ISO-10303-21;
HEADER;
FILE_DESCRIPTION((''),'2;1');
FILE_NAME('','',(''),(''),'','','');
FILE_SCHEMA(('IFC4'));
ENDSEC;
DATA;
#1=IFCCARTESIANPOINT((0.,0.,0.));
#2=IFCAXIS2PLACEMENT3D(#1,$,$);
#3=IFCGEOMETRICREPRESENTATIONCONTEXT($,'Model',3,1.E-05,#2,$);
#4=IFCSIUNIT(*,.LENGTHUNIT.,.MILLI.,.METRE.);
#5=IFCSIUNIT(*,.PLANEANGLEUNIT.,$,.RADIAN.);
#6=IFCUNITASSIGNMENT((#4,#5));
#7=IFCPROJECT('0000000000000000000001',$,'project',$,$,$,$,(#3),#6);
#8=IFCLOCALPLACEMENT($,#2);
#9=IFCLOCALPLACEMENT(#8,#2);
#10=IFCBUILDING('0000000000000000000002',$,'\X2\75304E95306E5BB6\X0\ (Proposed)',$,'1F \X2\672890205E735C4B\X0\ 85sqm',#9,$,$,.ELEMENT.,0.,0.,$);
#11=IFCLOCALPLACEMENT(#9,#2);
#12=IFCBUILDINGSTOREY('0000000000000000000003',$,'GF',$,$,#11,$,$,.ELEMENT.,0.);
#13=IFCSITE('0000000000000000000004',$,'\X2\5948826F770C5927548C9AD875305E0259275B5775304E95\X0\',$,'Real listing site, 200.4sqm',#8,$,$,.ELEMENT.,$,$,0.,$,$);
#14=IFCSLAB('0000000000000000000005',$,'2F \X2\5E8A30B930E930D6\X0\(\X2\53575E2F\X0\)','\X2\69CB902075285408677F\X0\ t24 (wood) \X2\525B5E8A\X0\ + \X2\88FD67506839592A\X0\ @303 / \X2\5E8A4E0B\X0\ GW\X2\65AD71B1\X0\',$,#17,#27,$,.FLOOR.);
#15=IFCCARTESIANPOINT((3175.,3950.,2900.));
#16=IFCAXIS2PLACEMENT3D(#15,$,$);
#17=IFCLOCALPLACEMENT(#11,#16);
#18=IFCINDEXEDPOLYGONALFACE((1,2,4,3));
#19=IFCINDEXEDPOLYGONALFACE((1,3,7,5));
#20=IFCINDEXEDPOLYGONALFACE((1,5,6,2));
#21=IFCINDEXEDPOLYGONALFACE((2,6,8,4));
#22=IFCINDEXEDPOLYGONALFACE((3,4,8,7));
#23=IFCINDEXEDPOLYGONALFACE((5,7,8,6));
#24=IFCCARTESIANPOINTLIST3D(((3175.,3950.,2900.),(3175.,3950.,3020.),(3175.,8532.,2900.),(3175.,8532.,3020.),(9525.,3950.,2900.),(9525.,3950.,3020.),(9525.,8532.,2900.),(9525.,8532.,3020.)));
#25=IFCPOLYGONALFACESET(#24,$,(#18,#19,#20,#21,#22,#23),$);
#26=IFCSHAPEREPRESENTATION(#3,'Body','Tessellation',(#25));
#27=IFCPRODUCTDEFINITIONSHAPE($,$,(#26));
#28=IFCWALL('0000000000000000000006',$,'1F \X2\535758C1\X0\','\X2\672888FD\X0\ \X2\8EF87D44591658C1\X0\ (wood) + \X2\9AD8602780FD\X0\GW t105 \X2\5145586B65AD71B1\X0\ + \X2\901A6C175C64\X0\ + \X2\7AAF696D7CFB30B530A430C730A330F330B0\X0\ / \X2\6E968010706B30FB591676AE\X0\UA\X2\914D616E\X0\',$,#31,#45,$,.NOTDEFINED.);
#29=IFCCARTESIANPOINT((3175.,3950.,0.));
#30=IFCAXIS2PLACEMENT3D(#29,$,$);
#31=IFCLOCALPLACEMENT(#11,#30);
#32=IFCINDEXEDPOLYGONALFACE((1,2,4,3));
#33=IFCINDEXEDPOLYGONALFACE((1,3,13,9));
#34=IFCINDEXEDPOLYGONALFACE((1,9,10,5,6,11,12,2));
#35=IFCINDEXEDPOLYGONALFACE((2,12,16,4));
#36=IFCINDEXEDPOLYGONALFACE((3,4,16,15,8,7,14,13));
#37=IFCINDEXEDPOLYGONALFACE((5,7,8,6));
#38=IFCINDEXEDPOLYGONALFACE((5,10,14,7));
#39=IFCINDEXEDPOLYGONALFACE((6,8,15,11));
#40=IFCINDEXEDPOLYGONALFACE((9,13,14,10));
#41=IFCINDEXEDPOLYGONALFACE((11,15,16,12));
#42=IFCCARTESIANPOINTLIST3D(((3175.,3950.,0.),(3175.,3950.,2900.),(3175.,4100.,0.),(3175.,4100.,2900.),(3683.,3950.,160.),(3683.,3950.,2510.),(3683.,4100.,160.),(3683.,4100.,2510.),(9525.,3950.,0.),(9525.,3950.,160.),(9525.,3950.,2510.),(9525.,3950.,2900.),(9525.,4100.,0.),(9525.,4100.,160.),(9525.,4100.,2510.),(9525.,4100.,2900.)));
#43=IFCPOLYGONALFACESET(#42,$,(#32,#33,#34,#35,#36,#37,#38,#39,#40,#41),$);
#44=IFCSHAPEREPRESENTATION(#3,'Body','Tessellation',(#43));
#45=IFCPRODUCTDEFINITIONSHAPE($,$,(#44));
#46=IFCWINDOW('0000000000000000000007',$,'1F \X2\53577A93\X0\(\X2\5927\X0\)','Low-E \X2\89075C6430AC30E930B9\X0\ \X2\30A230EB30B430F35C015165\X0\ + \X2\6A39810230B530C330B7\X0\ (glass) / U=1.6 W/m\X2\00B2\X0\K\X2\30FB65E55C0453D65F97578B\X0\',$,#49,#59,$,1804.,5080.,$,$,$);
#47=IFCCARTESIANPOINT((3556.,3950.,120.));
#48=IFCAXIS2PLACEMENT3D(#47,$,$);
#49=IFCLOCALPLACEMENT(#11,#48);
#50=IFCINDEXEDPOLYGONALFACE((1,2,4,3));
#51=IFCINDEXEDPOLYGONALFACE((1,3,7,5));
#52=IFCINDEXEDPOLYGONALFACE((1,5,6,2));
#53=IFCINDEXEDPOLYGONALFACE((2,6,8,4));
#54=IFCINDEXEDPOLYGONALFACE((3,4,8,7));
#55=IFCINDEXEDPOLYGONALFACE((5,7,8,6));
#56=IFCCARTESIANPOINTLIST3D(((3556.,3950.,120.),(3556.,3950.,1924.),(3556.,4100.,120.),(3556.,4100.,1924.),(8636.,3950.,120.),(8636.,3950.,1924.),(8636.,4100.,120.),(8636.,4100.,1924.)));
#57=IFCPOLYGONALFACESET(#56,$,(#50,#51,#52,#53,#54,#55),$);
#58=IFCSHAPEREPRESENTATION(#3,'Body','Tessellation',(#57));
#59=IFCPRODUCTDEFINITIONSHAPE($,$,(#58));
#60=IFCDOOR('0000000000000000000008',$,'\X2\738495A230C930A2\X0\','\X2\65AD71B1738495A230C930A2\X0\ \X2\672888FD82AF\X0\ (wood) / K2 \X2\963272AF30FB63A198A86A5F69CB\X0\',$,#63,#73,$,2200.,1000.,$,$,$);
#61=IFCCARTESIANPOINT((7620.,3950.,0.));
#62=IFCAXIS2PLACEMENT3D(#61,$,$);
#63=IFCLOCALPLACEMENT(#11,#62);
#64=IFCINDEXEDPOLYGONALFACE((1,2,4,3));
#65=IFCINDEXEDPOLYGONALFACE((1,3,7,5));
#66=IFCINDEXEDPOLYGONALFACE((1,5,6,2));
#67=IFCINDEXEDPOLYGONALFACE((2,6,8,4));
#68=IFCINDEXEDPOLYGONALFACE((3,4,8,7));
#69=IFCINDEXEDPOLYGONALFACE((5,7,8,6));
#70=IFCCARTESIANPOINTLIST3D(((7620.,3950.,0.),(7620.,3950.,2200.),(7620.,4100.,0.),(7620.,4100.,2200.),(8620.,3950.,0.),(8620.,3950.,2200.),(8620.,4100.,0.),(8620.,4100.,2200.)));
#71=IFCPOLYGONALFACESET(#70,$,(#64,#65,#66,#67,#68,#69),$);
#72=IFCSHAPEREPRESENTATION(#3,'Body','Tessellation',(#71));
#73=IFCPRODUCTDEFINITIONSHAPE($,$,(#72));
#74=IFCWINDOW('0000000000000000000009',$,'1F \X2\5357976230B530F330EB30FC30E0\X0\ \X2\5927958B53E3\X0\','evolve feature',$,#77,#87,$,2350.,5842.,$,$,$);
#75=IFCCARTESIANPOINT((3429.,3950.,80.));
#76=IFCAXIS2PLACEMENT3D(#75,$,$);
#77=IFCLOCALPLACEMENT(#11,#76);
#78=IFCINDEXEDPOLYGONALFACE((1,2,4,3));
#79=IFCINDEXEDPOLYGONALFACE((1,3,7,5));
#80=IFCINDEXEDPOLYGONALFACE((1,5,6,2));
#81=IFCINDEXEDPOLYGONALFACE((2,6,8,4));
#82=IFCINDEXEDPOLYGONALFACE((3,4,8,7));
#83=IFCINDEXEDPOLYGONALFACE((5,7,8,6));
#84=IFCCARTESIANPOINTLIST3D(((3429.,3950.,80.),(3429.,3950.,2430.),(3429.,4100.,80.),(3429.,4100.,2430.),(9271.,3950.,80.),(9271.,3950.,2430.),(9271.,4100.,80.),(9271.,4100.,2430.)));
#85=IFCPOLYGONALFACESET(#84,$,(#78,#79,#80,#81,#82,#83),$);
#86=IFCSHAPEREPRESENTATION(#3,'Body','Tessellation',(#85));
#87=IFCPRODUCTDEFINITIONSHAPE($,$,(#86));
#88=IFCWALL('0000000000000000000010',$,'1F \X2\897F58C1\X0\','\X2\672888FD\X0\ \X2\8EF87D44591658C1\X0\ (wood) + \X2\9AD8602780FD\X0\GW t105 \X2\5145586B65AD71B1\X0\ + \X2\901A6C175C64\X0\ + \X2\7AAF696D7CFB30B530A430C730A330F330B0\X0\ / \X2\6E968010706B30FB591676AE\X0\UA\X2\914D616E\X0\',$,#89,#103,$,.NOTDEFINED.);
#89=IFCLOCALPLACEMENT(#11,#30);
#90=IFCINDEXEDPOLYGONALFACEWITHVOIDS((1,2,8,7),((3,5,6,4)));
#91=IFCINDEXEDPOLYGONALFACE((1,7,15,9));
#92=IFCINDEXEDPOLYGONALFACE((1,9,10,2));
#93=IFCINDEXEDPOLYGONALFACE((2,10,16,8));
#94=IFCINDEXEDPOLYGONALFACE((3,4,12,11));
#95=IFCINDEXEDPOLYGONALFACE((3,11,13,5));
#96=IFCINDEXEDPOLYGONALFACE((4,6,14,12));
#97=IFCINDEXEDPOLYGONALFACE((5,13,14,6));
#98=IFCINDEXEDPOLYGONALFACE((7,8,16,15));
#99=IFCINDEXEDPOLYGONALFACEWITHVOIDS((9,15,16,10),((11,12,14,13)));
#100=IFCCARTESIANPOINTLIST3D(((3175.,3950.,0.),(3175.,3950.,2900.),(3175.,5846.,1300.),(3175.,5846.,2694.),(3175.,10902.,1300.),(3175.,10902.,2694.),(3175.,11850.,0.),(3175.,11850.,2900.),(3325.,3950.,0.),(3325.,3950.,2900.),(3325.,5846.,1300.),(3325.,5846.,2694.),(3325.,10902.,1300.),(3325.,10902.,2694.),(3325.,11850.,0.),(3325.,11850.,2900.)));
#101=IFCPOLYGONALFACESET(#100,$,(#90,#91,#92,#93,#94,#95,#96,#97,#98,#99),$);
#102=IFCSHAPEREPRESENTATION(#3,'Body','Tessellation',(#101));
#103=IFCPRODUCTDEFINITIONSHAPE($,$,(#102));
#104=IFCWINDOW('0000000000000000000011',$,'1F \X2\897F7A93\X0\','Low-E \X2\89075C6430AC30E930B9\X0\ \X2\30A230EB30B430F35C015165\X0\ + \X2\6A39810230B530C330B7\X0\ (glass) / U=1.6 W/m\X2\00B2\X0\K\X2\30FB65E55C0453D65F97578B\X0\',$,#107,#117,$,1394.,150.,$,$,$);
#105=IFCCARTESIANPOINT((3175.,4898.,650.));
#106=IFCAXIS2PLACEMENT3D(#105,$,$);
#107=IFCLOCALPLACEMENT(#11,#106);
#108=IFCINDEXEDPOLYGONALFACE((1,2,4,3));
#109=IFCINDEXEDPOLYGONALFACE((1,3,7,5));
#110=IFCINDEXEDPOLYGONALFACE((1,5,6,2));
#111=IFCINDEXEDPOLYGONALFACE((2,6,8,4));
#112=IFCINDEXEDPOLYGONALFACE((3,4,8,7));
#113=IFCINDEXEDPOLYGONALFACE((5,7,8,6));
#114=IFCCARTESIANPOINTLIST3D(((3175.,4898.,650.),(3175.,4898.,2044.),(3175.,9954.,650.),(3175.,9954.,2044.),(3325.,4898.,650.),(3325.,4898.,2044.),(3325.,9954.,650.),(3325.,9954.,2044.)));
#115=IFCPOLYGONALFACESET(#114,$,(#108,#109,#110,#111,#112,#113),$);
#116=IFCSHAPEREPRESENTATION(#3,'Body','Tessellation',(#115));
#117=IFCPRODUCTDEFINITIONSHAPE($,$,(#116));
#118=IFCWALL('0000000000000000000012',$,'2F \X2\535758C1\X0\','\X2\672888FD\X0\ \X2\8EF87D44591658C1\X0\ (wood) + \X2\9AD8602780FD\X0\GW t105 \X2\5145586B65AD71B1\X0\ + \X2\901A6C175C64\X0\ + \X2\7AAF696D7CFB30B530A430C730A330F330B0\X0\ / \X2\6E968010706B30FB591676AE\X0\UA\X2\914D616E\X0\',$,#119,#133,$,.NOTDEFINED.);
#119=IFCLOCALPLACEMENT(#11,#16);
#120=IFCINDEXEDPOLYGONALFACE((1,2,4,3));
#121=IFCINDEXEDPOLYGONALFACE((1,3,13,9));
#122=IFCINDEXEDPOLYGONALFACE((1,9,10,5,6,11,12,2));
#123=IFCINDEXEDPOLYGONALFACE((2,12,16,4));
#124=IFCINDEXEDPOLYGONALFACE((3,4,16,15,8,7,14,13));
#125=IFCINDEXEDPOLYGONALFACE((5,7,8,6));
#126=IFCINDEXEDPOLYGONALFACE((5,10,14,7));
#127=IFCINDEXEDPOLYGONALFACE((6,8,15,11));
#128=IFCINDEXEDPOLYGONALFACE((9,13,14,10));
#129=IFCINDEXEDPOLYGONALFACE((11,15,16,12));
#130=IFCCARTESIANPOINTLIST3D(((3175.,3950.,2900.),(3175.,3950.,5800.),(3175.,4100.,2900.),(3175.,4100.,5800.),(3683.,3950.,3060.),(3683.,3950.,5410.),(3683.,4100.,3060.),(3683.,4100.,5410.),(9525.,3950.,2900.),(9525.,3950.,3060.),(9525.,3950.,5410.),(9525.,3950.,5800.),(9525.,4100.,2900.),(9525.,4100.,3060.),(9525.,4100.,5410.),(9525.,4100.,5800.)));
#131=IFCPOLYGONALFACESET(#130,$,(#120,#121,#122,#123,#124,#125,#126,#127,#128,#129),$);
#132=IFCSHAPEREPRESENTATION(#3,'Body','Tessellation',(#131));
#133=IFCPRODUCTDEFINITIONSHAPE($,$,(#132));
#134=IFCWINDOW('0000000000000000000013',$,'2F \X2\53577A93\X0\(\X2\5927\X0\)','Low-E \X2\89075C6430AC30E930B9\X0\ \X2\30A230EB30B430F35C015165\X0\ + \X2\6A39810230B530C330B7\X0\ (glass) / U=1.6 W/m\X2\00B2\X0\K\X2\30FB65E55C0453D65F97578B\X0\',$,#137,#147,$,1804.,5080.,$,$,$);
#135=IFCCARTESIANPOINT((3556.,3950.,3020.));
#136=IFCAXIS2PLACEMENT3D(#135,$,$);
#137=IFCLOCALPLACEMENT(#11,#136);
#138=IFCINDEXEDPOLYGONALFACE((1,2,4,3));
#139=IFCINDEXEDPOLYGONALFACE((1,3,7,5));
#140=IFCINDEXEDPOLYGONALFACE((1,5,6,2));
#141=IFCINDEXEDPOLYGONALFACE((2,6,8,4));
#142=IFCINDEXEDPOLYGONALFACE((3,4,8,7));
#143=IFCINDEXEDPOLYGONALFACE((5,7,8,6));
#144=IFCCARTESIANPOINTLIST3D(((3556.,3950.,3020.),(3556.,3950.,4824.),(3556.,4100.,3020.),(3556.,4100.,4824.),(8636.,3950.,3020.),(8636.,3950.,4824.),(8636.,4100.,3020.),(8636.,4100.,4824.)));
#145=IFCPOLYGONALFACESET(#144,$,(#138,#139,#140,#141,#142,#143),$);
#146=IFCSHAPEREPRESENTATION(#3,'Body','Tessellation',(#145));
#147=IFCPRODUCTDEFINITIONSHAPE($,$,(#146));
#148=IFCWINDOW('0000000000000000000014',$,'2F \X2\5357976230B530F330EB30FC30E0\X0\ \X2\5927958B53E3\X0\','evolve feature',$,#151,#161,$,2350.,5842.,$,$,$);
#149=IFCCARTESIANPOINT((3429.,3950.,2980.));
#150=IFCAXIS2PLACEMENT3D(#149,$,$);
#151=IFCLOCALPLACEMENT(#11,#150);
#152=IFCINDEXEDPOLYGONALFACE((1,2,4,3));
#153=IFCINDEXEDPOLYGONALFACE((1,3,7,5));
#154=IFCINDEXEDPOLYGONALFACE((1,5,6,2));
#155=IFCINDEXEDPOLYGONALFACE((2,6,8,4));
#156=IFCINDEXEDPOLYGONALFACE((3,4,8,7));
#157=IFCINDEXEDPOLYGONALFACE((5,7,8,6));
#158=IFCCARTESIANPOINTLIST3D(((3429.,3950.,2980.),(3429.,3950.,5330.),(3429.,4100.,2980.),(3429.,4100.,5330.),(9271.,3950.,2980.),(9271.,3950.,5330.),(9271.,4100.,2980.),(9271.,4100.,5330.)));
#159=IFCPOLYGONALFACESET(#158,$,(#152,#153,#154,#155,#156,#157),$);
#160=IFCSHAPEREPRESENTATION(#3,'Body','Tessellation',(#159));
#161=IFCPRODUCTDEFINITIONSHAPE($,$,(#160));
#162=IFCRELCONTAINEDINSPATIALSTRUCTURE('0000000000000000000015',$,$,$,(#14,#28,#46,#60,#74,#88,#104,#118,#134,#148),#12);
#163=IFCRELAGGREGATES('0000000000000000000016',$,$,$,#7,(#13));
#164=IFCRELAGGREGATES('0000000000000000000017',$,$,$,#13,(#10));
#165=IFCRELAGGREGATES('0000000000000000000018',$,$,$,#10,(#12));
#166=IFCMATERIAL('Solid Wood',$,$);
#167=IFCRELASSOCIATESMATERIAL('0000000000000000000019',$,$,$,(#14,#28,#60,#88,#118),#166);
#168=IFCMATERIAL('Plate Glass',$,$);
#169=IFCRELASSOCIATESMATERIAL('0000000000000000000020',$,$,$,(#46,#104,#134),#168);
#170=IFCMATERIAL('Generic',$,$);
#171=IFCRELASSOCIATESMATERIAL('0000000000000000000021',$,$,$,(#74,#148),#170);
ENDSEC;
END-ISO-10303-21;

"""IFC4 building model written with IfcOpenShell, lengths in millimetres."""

from ifc_helpers import new_model, si_unit, frame, frame_2d, origin, place, context, project, spatial, rectangle, extrude, material, element, fill, save


model = new_model("IFC4")

# Units and contexts
model_context = context("Model", 3, precision=1e-05, world=origin())
ifc_project = project(units=[si_unit("LENGTHUNIT", "METRE", prefix="MILLI"), si_unit("PLANEANGLEUNIT", "RADIAN")], contexts=[model_context])

# Site, building, storey
site_placement = place(None, origin())
site = spatial("IfcSite", under=ifc_project, at=site_placement, Name="奈良県大和高田市大字田井", ObjectType="Real listing site, 200.4sqm", CompositionType="ELEMENT", RefElevation=0.0)
building_placement = place(site_placement, origin())
building = spatial("IfcBuilding", under=site, at=building_placement, Name="田井の家 (Proposed)", ObjectType="1F 木造平屋 85sqm", CompositionType="ELEMENT", ElevationOfRefHeight=0.0, ElevationOfTerrain=0.0)
storey_placement = place(building_placement, origin())
storey = spatial("IfcBuildingStorey", under=building, at=storey_placement, Name="GF", CompositionType="ELEMENT", Elevation=0.0)

# Slab
ifc_material_1 = material(Name="Solid Wood")
slab_1_placement = place(storey_placement, frame((3175.0, 3950.0, 2900.0)))
element("IfcSlab", 1, at=slab_1_placement, inside=storey, material=ifc_material_1, Name="2F 床スラブ(南帯)", Description="構造用合板 t24 (wood) 剛床 + 製材根太 @303 / 床下 GW断熱", PredefinedType="FLOOR", context=model_context, shape_type="SweptSolid", body=[
    extrude(rectangle(XDim=6350.0, YDim=4582.0, at=frame_2d((3175.0, 2291.0))), frame((3175.0, 3950.0, 2900.0)), (0.0, 0.0, 1.0), 120.0),
])
ifc_material_2 = material(Name="Generic")

# Wall, openings, windows, door
wall_1_placement = place(storey_placement, frame((3175.0, 3950.0, 0.0)))
wall_1 = element("IfcWall", 2, at=wall_1_placement, inside=storey, material=ifc_material_1, Name="1F 南壁", Description="木製 軸組外壁 (wood) + 高性能GW t105 充填断熱 + 通気層 + 窯業系サイディング / 準耐火・外皮UA配慮", PredefinedType="NOTDEFINED", context=model_context, shape_type="SweptSolid", body=[
    extrude(rectangle(XDim=6350.0, YDim=150.0, at=frame_2d((3175.0, 75.0))), frame((3175.0, 3950.0, 0.0)), (0.0, 0.0, 1.0), 2900.0),
])
opening_1_placement = place(storey_placement, frame((3556.0, 3950.0, 120.0)))
opening_1 = element("IfcOpeningElement", 3, at=opening_1_placement, cuts=wall_1, PredefinedType="NOTDEFINED", context=model_context, shape_type="SweptSolid", body=[
    extrude(rectangle(XDim=5080.0, YDim=150.0, at=frame_2d((2540.0, 75.0))), frame((3556.0, 3950.0, 120.0)), (0.0, 0.0, 1.0), 1804.0),
])
opening_2_placement = place(storey_placement, frame((7620.0, 3950.0, 0.0)))
opening_2 = element("IfcOpeningElement", 4, at=opening_2_placement, cuts=wall_1, PredefinedType="NOTDEFINED", context=model_context, shape_type="SweptSolid", body=[
    extrude(rectangle(XDim=1000.0, YDim=150.0, at=frame_2d((500.0, 75.0))), frame((7620.0, 3950.0, 0.0)), (0.0, 0.0, 1.0), 2200.0),
])
opening_3_placement = place(storey_placement, frame((3429.0, 3950.0, 80.0)))
opening_3 = element("IfcOpeningElement", 5, at=opening_3_placement, cuts=wall_1, PredefinedType="NOTDEFINED", context=model_context, shape_type="SweptSolid", body=[
    extrude(rectangle(XDim=5842.0, YDim=150.0, at=frame_2d((2921.0, 75.0))), frame((3429.0, 3950.0, 80.0)), (0.0, 0.0, 1.0), 2350.0),
])
ifc_material_3 = material(Name="Plate Glass")
window_1_placement = place(storey_placement, frame((3556.0, 3950.0, 120.0)))
window_1 = element("IfcWindow", 6, at=window_1_placement, inside=storey, material=ifc_material_3, Name="1F 南窓(大)", Description="Low-E 複層ガラス アルゴン封入 + 樹脂サッシ (glass) / U=1.6 W/m²K・日射取得型", OverallHeight=1804.0, OverallWidth=5080.0, context=model_context, shape_type="SweptSolid", body=[
    extrude(rectangle(XDim=5080.0, YDim=150.0, at=frame_2d((2540.0, 75.0))), frame((3556.0, 3950.0, 120.0)), (0.0, 0.0, 1.0), 1804.0),
])
fill(opening_1, window_1)
door_placement = place(storey_placement, frame((7620.0, 3950.0, 0.0)))
door = element("IfcDoor", 7, at=door_placement, inside=storey, material=ifc_material_1, Name="玄関ドア", Description="断熱玄関ドア 木製芯 (wood) / K2 防犯・採風機構", OverallHeight=2200.0, OverallWidth=1000.0, context=model_context, shape_type="SweptSolid", body=[
    extrude(rectangle(XDim=1000.0, YDim=150.0, at=frame_2d((500.0, 75.0))), frame((7620.0, 3950.0, 0.0)), (0.0, 0.0, 1.0), 2200.0),
])
fill(opening_2, door)
window_2_placement = place(storey_placement, frame((3429.0, 3950.0, 80.0)))
window_2 = element("IfcWindow", 8, at=window_2_placement, inside=storey, material=ifc_material_2, Name="1F 南面サンルーム 大開口", Description="evolve feature", OverallHeight=2350.0, OverallWidth=5842.0, context=model_context, shape_type="SweptSolid", body=[
    extrude(rectangle(XDim=5842.0, YDim=150.0, at=frame_2d((2921.0, 75.0))), frame((3429.0, 3950.0, 80.0)), (0.0, 0.0, 1.0), 2350.0),
])
fill(opening_3, window_2)

# Wall, opening, window
wall_2_placement = place(storey_placement, frame((3175.0, 3950.0, 0.0)))
wall_2 = element("IfcWall", 9, at=wall_2_placement, inside=storey, material=ifc_material_1, Name="1F 西壁", Description="木製 軸組外壁 (wood) + 高性能GW t105 充填断熱 + 通気層 + 窯業系サイディング / 準耐火・外皮UA配慮", PredefinedType="NOTDEFINED", context=model_context, shape_type="SweptSolid", body=[
    extrude(rectangle(XDim=150.0, YDim=7900.0, at=frame_2d((75.0, 3950.0))), frame((3175.0, 3950.0, 0.0)), (0.0, 0.0, 1.0), 2900.0),
])
opening_4_placement = place(storey_placement, frame((3175.0, 4898.0, 650.0)))
opening_4 = element("IfcOpeningElement", 10, at=opening_4_placement, cuts=wall_2, PredefinedType="NOTDEFINED", context=model_context, shape_type="SweptSolid", body=[
    extrude(rectangle(XDim=150.0, YDim=5056.0, at=frame_2d((75.0, 2528.0))), frame((3175.0, 4898.0, 650.0)), (0.0, 0.0, 1.0), 1394.0),
])
window_3_placement = place(storey_placement, frame((3175.0, 4898.0, 650.0)))
window_3 = element("IfcWindow", 11, at=window_3_placement, inside=storey, material=ifc_material_3, Name="1F 西窓", Description="Low-E 複層ガラス アルゴン封入 + 樹脂サッシ (glass) / U=1.6 W/m²K・日射取得型", OverallHeight=1394.0, OverallWidth=150.0, context=model_context, shape_type="SweptSolid", body=[
    extrude(rectangle(XDim=150.0, YDim=5056.0, at=frame_2d((75.0, 2528.0))), frame((3175.0, 4898.0, 650.0)), (0.0, 0.0, 1.0), 1394.0),
])
fill(opening_4, window_3)

# Wall, openings, windows
wall_3_placement = place(storey_placement, frame((3175.0, 3950.0, 2900.0)))
wall_3 = element("IfcWall", 12, at=wall_3_placement, inside=storey, material=ifc_material_1, Name="2F 南壁", Description="木製 軸組外壁 (wood) + 高性能GW t105 充填断熱 + 通気層 + 窯業系サイディング / 準耐火・外皮UA配慮", PredefinedType="NOTDEFINED", context=model_context, shape_type="SweptSolid", body=[
    extrude(rectangle(XDim=6350.0, YDim=150.0, at=frame_2d((3175.0, 75.0))), frame((3175.0, 3950.0, 2900.0)), (0.0, 0.0, 1.0), 2900.0),
])
opening_5_placement = place(storey_placement, frame((3556.0, 3950.0, 3020.0)))
opening_5 = element("IfcOpeningElement", 13, at=opening_5_placement, cuts=wall_3, PredefinedType="NOTDEFINED", context=model_context, shape_type="SweptSolid", body=[
    extrude(rectangle(XDim=5080.0, YDim=150.0, at=frame_2d((2540.0, 75.0))), frame((3556.0, 3950.0, 3020.0)), (0.0, 0.0, 1.0), 1804.0),
])
opening_6_placement = place(storey_placement, frame((3429.0, 3950.0, 2980.0)))
opening_6 = element("IfcOpeningElement", 14, at=opening_6_placement, cuts=wall_3, PredefinedType="NOTDEFINED", context=model_context, shape_type="SweptSolid", body=[
    extrude(rectangle(XDim=5842.0, YDim=150.0, at=frame_2d((2921.0, 75.0))), frame((3429.0, 3950.0, 2980.0)), (0.0, 0.0, 1.0), 2350.0),
])
window_4_placement = place(storey_placement, frame((3556.0, 3950.0, 3020.0)))
window_4 = element("IfcWindow", 15, at=window_4_placement, inside=storey, material=ifc_material_3, Name="2F 南窓(大)", Description="Low-E 複層ガラス アルゴン封入 + 樹脂サッシ (glass) / U=1.6 W/m²K・日射取得型", OverallHeight=1804.0, OverallWidth=5080.0, context=model_context, shape_type="SweptSolid", body=[
    extrude(rectangle(XDim=5080.0, YDim=150.0, at=frame_2d((2540.0, 75.0))), frame((3556.0, 3950.0, 3020.0)), (0.0, 0.0, 1.0), 1804.0),
])
fill(opening_5, window_4)
window_5_placement = place(storey_placement, frame((3429.0, 3950.0, 2980.0)))
window_5 = element("IfcWindow", 16, at=window_5_placement, inside=storey, material=ifc_material_2, Name="2F 南面サンルーム 大開口", Description="evolve feature", OverallHeight=2350.0, OverallWidth=5842.0, context=model_context, shape_type="SweptSolid", body=[
    extrude(rectangle(XDim=5842.0, YDim=150.0, at=frame_2d((2921.0, 75.0))), frame((3429.0, 3950.0, 2980.0)), (0.0, 0.0, 1.0), 2350.0),
])
fill(opening_6, window_5)

save(model, "model.ifc")
